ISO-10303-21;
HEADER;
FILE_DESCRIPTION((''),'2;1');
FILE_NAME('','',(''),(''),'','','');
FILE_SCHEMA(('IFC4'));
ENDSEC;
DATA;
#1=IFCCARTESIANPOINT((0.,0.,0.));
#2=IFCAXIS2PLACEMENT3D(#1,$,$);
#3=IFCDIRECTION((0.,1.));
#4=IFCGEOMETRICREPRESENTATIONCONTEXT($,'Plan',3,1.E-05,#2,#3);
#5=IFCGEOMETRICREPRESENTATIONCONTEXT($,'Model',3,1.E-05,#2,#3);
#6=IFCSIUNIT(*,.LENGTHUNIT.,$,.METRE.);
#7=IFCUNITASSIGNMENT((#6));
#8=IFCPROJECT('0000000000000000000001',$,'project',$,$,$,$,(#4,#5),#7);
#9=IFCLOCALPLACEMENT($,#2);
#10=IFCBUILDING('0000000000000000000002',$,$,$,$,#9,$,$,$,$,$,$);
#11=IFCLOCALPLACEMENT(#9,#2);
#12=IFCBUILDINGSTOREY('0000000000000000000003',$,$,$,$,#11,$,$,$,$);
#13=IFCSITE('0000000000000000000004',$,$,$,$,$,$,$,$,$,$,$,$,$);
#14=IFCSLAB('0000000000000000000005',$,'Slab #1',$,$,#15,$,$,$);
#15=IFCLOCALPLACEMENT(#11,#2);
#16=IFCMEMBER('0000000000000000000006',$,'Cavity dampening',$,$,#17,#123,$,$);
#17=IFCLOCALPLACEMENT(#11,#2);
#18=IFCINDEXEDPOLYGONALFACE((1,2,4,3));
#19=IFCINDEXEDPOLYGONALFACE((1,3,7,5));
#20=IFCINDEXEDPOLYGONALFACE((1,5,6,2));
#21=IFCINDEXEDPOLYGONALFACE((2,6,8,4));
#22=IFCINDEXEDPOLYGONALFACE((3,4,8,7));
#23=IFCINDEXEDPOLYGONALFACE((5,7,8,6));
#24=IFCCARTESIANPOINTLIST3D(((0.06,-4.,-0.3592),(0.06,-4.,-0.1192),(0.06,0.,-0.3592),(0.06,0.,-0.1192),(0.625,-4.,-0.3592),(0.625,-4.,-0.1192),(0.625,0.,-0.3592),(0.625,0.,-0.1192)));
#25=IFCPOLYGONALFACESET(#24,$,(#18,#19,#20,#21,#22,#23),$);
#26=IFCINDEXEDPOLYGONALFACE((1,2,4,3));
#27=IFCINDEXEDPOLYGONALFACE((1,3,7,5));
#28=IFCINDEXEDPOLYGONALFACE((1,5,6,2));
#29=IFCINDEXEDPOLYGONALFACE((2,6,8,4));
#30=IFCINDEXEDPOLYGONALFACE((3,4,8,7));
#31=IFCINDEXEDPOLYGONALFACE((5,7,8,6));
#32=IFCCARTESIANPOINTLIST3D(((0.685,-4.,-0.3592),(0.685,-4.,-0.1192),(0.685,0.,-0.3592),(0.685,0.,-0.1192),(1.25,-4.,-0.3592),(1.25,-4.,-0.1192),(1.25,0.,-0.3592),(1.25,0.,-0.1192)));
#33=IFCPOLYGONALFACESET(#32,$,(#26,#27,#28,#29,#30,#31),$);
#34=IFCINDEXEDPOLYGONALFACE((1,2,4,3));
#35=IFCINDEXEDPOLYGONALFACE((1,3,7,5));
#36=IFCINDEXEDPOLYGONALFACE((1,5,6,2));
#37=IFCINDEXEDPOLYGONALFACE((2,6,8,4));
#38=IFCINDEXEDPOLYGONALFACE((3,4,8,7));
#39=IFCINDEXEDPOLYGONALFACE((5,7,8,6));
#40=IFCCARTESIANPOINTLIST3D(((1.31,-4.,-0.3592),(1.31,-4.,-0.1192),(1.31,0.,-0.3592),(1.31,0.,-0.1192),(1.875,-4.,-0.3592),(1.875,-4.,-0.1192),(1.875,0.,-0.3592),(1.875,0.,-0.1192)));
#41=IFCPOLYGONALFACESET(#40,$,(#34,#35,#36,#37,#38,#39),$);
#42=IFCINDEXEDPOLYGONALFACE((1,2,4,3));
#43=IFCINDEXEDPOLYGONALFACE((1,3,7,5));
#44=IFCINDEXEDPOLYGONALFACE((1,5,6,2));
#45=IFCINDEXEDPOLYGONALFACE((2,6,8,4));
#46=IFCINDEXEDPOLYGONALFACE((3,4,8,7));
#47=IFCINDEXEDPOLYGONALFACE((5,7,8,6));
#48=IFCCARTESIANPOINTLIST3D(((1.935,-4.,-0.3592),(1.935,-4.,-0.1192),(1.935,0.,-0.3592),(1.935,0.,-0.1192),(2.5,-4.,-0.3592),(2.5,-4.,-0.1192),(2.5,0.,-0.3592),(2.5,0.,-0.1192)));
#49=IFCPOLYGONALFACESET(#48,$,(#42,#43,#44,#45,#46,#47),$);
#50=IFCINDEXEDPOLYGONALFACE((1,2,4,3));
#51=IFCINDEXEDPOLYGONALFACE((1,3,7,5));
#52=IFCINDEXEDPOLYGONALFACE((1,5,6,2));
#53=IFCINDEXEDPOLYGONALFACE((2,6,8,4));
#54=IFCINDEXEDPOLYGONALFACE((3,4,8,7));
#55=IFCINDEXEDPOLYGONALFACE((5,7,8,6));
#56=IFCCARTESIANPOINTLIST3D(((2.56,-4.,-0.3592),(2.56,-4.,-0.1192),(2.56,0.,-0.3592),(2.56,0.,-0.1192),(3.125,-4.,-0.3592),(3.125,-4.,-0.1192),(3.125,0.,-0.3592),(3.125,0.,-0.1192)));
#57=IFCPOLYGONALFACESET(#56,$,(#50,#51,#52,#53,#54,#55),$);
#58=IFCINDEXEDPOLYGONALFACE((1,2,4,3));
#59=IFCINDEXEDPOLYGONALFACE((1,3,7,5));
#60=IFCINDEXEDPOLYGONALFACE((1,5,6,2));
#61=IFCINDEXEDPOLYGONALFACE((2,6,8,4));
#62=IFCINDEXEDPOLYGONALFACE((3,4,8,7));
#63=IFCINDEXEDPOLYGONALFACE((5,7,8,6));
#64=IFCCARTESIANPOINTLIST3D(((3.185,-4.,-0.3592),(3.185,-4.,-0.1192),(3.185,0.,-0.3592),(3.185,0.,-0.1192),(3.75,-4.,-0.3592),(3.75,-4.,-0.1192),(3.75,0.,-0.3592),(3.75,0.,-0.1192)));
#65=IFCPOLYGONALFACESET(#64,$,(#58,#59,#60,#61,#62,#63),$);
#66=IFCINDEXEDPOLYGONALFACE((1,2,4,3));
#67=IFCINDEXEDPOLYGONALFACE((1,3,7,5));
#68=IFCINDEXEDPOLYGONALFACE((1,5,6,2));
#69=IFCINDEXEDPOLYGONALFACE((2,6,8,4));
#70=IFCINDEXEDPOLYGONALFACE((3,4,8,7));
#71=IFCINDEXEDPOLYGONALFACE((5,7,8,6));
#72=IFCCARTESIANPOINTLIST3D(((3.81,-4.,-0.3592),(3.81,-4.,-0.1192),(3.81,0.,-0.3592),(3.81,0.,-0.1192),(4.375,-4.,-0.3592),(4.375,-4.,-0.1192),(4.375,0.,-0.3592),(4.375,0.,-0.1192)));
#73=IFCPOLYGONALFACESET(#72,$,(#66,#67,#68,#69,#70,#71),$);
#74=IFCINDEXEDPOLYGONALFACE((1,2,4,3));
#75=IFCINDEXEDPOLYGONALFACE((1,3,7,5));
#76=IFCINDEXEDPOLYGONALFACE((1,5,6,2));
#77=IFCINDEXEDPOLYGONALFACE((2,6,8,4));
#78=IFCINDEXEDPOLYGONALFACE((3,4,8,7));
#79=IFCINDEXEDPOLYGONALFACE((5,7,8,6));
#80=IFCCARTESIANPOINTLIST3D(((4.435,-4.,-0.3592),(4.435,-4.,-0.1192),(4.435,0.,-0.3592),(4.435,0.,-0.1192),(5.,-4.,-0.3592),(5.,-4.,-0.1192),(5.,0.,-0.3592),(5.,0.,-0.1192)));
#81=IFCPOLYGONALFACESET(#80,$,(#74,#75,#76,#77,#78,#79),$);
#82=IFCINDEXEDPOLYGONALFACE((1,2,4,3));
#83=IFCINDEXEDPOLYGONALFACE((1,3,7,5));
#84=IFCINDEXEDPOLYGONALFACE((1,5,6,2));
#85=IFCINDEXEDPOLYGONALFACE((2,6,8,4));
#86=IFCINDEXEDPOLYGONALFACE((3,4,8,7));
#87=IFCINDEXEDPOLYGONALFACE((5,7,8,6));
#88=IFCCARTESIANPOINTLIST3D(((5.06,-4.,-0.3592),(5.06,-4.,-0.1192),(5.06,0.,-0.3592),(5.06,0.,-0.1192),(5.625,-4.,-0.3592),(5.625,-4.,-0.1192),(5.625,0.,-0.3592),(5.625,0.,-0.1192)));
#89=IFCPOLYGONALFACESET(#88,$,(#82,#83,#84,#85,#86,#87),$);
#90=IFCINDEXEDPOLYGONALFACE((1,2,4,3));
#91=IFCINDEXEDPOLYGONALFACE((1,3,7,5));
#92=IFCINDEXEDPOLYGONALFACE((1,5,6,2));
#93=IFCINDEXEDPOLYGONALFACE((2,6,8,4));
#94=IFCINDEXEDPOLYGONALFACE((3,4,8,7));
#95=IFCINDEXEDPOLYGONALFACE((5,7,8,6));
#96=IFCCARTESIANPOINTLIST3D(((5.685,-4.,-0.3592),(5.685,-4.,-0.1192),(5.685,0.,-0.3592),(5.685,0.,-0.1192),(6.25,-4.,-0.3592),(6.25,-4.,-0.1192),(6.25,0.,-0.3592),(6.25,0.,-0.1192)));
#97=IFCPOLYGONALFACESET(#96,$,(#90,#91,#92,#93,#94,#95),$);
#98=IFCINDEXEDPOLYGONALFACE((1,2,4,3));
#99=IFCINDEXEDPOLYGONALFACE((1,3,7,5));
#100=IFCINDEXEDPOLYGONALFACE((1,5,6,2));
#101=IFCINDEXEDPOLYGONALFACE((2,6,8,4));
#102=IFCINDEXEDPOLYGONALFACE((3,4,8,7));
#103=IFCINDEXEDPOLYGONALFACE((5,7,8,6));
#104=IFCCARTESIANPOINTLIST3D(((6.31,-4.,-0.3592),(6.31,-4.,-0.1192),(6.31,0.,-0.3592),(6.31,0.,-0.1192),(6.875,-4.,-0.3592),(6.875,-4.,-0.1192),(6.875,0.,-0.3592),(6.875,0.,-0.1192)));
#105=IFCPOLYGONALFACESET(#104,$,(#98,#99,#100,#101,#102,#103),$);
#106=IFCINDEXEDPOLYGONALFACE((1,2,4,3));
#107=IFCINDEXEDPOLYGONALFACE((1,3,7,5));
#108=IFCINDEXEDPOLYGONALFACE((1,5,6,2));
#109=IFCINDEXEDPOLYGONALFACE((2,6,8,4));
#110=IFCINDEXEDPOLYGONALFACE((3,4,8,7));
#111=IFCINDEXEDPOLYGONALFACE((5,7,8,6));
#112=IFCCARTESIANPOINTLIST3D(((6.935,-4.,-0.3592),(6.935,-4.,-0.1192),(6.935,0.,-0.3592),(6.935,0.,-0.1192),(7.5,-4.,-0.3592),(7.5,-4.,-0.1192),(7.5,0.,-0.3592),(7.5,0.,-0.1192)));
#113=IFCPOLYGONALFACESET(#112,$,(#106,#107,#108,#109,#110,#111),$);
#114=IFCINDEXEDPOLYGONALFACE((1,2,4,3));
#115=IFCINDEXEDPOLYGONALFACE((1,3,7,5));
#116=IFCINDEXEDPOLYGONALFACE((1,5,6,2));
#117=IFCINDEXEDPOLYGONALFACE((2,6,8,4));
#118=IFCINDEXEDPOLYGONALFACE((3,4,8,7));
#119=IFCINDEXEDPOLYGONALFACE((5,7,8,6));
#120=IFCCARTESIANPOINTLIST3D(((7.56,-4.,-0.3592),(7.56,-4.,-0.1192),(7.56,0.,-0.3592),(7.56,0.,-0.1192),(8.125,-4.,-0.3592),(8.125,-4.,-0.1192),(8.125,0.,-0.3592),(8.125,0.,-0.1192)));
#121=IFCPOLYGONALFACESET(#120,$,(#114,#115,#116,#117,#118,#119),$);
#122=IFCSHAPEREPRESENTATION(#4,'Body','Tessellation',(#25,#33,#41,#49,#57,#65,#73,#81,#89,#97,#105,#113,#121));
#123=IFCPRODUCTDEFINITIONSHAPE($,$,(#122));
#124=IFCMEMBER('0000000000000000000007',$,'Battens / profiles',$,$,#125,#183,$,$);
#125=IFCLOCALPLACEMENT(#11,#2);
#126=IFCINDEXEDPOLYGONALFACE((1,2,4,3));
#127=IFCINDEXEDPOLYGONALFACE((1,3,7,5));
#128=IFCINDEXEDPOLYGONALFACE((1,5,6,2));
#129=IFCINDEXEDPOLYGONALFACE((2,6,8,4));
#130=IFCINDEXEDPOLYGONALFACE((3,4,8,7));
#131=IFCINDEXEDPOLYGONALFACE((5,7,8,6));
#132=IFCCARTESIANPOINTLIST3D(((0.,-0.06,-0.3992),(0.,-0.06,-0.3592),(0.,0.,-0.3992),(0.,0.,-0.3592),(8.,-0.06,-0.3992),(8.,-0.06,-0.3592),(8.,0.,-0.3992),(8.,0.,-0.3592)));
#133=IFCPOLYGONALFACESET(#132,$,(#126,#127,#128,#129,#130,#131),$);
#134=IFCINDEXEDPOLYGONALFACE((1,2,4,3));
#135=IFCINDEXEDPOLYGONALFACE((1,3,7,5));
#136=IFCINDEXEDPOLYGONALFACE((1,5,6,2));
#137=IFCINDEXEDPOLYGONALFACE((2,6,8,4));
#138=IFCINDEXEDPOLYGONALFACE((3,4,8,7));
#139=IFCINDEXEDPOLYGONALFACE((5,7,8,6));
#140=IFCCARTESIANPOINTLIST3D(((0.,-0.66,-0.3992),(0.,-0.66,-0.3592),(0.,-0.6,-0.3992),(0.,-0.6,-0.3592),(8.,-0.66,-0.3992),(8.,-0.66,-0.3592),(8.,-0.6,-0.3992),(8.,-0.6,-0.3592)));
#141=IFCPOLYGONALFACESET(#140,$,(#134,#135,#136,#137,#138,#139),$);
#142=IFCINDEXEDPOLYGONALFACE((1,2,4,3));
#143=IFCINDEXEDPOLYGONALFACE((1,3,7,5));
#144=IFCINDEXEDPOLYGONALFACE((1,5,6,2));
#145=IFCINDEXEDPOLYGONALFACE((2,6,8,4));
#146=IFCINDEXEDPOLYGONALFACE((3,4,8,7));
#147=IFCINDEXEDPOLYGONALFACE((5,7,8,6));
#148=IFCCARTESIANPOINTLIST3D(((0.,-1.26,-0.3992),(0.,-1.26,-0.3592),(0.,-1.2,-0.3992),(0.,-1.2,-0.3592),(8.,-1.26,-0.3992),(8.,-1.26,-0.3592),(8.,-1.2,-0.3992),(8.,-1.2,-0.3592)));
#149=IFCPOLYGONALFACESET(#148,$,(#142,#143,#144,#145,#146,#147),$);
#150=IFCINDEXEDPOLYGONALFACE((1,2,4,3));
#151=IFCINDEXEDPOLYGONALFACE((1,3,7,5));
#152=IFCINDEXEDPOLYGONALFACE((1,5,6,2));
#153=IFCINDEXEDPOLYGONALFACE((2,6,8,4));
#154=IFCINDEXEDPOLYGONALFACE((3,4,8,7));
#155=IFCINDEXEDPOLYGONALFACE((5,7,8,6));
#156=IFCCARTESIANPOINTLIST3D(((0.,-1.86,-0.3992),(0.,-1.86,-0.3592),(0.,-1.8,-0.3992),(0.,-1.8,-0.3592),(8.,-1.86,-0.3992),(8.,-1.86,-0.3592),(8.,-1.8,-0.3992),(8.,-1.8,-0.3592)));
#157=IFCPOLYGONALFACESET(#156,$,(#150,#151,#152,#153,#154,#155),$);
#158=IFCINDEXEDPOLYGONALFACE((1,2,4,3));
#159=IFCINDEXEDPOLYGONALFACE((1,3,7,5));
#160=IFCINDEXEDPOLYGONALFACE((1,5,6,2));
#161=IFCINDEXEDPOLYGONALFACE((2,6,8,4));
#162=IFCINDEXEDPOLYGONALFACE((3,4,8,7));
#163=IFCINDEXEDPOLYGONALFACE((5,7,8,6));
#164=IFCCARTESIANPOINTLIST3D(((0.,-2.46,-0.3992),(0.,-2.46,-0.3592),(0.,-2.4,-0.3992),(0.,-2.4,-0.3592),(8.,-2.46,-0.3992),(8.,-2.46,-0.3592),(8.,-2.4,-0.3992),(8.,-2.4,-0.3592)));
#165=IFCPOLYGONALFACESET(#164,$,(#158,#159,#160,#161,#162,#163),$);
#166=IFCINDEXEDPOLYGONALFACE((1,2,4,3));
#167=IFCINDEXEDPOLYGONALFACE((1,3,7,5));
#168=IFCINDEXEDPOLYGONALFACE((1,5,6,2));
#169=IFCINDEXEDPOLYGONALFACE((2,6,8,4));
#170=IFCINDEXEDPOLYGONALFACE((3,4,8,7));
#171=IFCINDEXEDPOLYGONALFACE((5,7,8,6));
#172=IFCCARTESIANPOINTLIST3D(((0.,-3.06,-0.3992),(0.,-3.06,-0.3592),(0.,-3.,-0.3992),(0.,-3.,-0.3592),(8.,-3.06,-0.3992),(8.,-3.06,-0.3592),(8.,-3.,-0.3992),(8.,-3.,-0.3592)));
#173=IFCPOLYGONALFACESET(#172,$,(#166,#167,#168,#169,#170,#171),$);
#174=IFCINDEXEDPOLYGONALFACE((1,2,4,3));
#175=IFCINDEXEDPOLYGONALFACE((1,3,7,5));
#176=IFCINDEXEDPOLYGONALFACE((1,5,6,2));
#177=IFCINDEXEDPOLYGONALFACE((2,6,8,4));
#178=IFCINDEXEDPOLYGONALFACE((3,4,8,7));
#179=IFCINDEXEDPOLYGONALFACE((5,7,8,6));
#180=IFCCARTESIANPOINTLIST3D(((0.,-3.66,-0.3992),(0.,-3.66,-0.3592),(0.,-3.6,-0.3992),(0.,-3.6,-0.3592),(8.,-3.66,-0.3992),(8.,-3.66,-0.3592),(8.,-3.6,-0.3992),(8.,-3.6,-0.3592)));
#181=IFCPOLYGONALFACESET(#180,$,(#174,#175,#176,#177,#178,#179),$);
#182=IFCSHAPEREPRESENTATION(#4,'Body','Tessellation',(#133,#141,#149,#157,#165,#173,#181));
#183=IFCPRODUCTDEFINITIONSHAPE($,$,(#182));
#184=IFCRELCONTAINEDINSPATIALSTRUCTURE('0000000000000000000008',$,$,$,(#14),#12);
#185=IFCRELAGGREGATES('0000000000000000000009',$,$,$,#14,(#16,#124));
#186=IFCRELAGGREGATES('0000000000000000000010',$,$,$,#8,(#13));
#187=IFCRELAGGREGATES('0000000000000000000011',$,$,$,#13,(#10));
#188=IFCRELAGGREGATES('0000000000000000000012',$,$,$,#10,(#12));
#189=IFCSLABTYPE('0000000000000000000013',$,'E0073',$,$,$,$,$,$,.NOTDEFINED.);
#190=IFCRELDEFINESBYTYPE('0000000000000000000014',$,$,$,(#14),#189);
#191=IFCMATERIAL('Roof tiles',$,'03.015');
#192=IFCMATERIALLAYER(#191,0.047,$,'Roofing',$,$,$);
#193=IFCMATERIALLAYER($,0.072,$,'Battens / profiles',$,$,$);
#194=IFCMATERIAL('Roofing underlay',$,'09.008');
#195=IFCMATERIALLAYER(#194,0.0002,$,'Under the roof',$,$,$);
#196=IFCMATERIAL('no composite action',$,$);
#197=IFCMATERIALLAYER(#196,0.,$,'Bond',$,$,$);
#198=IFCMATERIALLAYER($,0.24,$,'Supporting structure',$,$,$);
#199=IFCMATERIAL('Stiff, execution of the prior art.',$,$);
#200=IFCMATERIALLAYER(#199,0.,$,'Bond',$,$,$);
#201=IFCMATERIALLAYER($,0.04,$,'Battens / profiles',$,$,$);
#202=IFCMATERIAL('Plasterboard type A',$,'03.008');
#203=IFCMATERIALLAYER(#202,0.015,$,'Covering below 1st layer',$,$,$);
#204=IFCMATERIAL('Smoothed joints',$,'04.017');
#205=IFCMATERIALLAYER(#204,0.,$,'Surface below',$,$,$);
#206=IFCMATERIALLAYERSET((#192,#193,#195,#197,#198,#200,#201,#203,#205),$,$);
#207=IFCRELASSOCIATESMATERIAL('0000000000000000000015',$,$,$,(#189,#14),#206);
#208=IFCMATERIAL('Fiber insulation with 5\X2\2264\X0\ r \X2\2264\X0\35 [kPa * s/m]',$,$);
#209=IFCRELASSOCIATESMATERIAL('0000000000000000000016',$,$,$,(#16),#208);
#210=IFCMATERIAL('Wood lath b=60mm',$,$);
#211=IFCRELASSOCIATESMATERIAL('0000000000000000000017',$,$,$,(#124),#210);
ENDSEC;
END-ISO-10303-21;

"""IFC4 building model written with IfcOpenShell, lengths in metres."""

from ifc_helpers import new_model, si_unit, direction, frame, frame_2d, origin, place, context, project, spatial, rectangle, extrude, material, layer, layer_set, type_object, element, aggregate, save


model = new_model("IFC4")

# Units and contexts
plan_context = context("Plan", 3, precision=1e-05, world=origin(), true_north=direction((0.0, 1.0)))
model_context = context("Model", 3, precision=1e-05, world=origin(), true_north=direction((0.0, 1.0)))
ifc_project = project(units=[si_unit("LENGTHUNIT", "METRE")], contexts=[plan_context, model_context])

# Site, building, storey
site = spatial("IfcSite", under=ifc_project)
building_placement = place(None, origin())
building = spatial("IfcBuilding", under=site, at=building_placement)
storey_placement = place(building_placement, origin())
storey = spatial("IfcBuildingStorey", under=building, at=storey_placement)

# Slab, members
ifc_material_1 = material(Name="Roof tiles", Category="03.015")
ifc_layer_1 = layer(ifc_material_1, 0.047, Name="Roofing")
ifc_layer_2 = layer(None, 0.072, Name="Battens / profiles")
ifc_material_2 = material(Name="Roofing underlay", Category="09.008")
ifc_layer_3 = layer(ifc_material_2, 0.0002, Name="Under the roof")
ifc_material_3 = material(Name="no composite action")
ifc_layer_4 = layer(ifc_material_3, 0.0, Name="Bond")
ifc_layer_5 = layer(None, 0.24, Name="Supporting structure")
ifc_material_4 = material(Name="Stiff, execution of the prior art.")
ifc_layer_6 = layer(ifc_material_4, 0.0, Name="Bond")
ifc_layer_7 = layer(None, 0.04, Name="Battens / profiles")
ifc_material_5 = material(Name="Plasterboard type A", Category="03.008")
ifc_layer_8 = layer(ifc_material_5, 0.015, Name="Covering below 1st layer")
ifc_material_6 = material(Name="Smoothed joints", Category="04.017")
ifc_layer_9 = layer(ifc_material_6, 0.0, Name="Surface below")
ifc_layer_set = layer_set([ifc_layer_1, ifc_layer_2, ifc_layer_3, ifc_layer_4, ifc_layer_5, ifc_layer_6, ifc_layer_7, ifc_layer_8, ifc_layer_9])
slab_type = type_object("IfcSlabType", Name="E0073", PredefinedType="NOTDEFINED", material=ifc_layer_set)
slab_placement = place(None, frame((0.0, 0.0, 0.0), z_axis=(0.0, 0.0, -1.0), x_axis=(1.0, 0.0, 0.0)))
slab = element("IfcSlab", 1, at=slab_placement, inside=storey, type_object=slab_type, material=ifc_layer_set, Name="Slab #1")
ifc_material_7 = material(Name="Fiber insulation with 5≤ r ≤35 [kPa * s/m]")
member_1_placement = place(slab_placement, origin())
member_1 = element("IfcMember", 2, at=member_1_placement, material=ifc_material_7, Name="Cavity dampening", context=plan_context, shape_type="SweptSolid", body=[
    extrude(rectangle(XDim=0.565, YDim=0.24, at=frame_2d((0.2825, 0.12), x_axis=(1.0, 0.0))), frame((0.06, 4.0, 0.1192), z_axis=(0.0, -1.0, 0.0), x_axis=(1.0, 0.0, 0.0)), (0.0, 0.0, 1.0), 4.0),
    extrude(rectangle(XDim=0.565, YDim=0.24, at=frame_2d((0.2825, 0.12), x_axis=(1.0, 0.0))), frame((0.685, 4.0, 0.1192), z_axis=(0.0, -1.0, 0.0), x_axis=(1.0, 0.0, 0.0)), (0.0, 0.0, 1.0), 4.0),
    extrude(rectangle(XDim=0.565, YDim=0.24, at=frame_2d((0.2825, 0.12), x_axis=(1.0, 0.0))), frame((1.31, 4.0, 0.1192), z_axis=(0.0, -1.0, 0.0), x_axis=(1.0, 0.0, 0.0)), (0.0, 0.0, 1.0), 4.0),
    extrude(rectangle(XDim=0.565, YDim=0.24, at=frame_2d((0.2825, 0.12), x_axis=(1.0, 0.0))), frame((1.935, 4.0, 0.1192), z_axis=(0.0, -1.0, 0.0), x_axis=(1.0, 0.0, 0.0)), (0.0, 0.0, 1.0), 4.0),
    extrude(rectangle(XDim=0.565, YDim=0.24, at=frame_2d((0.2825, 0.12), x_axis=(1.0, 0.0))), frame((2.56, 4.0, 0.1192), z_axis=(0.0, -1.0, 0.0), x_axis=(1.0, 0.0, 0.0)), (0.0, 0.0, 1.0), 4.0),
    extrude(rectangle(XDim=0.565, YDim=0.24, at=frame_2d((0.2825, 0.12), x_axis=(1.0, 0.0))), frame((3.185, 4.0, 0.1192), z_axis=(0.0, -1.0, 0.0), x_axis=(1.0, 0.0, 0.0)), (0.0, 0.0, 1.0), 4.0),
    extrude(rectangle(XDim=0.565, YDim=0.24, at=frame_2d((0.2825, 0.12), x_axis=(1.0, 0.0))), frame((3.81, 4.0, 0.1192), z_axis=(0.0, -1.0, 0.0), x_axis=(1.0, 0.0, 0.0)), (0.0, 0.0, 1.0), 4.0),
    extrude(rectangle(XDim=0.565, YDim=0.24, at=frame_2d((0.2825, 0.12), x_axis=(1.0, 0.0))), frame((4.435, 4.0, 0.1192), z_axis=(0.0, -1.0, 0.0), x_axis=(1.0, 0.0, 0.0)), (0.0, 0.0, 1.0), 4.0),
    extrude(rectangle(XDim=0.565, YDim=0.24, at=frame_2d((0.2825, 0.12), x_axis=(1.0, 0.0))), frame((5.06, 4.0, 0.1192), z_axis=(0.0, -1.0, 0.0), x_axis=(1.0, 0.0, 0.0)), (0.0, 0.0, 1.0), 4.0),
    extrude(rectangle(XDim=0.565, YDim=0.24, at=frame_2d((0.2825, 0.12), x_axis=(1.0, 0.0))), frame((5.685, 4.0, 0.1192), z_axis=(0.0, -1.0, 0.0), x_axis=(1.0, 0.0, 0.0)), (0.0, 0.0, 1.0), 4.0),
    extrude(rectangle(XDim=0.565, YDim=0.24, at=frame_2d((0.2825, 0.12), x_axis=(1.0, 0.0))), frame((6.31, 4.0, 0.1192), z_axis=(0.0, -1.0, 0.0), x_axis=(1.0, 0.0, 0.0)), (0.0, 0.0, 1.0), 4.0),
    extrude(rectangle(XDim=0.565, YDim=0.24, at=frame_2d((0.2825, 0.12), x_axis=(1.0, 0.0))), frame((6.935, 4.0, 0.1192), z_axis=(0.0, -1.0, 0.0), x_axis=(1.0, 0.0, 0.0)), (0.0, 0.0, 1.0), 4.0),
    extrude(rectangle(XDim=0.565, YDim=0.24, at=frame_2d((0.2825, 0.12), x_axis=(1.0, 0.0))), frame((7.56, 4.0, 0.1192), z_axis=(0.0, -1.0, 0.0), x_axis=(1.0, 0.0, 0.0)), (0.0, 0.0, 1.0), 4.0),
])
ifc_material_8 = material(Name="Wood lath b=60mm")
member_2_placement = place(slab_placement, origin())
member_2 = element("IfcMember", 3, at=member_2_placement, material=ifc_material_8, Name="Battens / profiles", context=plan_context, shape_type="SweptSolid", body=[
    extrude(rectangle(XDim=0.06, YDim=0.04, at=frame_2d((0.03, 0.02), x_axis=(1.0, 0.0))), frame((0.0, 0.0, 0.3592), z_axis=(1.0, 0.0, 0.0), x_axis=(0.0, 1.0, 0.0)), (0.0, 0.0, 1.0), 8.0),
    extrude(rectangle(XDim=0.06, YDim=0.04, at=frame_2d((0.03, 0.02), x_axis=(1.0, 0.0))), frame((0.0, 0.6, 0.3592), z_axis=(1.0, 0.0, 0.0), x_axis=(0.0, 1.0, 0.0)), (0.0, 0.0, 1.0), 8.0),
    extrude(rectangle(XDim=0.06, YDim=0.04, at=frame_2d((0.03, 0.02), x_axis=(1.0, 0.0))), frame((0.0, 1.2, 0.3592), z_axis=(1.0, 0.0, 0.0), x_axis=(0.0, 1.0, 0.0)), (0.0, 0.0, 1.0), 8.0),
    extrude(rectangle(XDim=0.06, YDim=0.04, at=frame_2d((0.03, 0.02), x_axis=(1.0, 0.0))), frame((0.0, 1.8, 0.3592), z_axis=(1.0, 0.0, 0.0), x_axis=(0.0, 1.0, 0.0)), (0.0, 0.0, 1.0), 8.0),
    extrude(rectangle(XDim=0.06, YDim=0.04, at=frame_2d((0.03, 0.02), x_axis=(1.0, 0.0))), frame((0.0, 2.4, 0.3592), z_axis=(1.0, 0.0, 0.0), x_axis=(0.0, 1.0, 0.0)), (0.0, 0.0, 1.0), 8.0),
    extrude(rectangle(XDim=0.06, YDim=0.04, at=frame_2d((0.03, 0.02), x_axis=(1.0, 0.0))), frame((0.0, 3.0, 0.3592), z_axis=(1.0, 0.0, 0.0), x_axis=(0.0, 1.0, 0.0)), (0.0, 0.0, 1.0), 8.0),
    extrude(rectangle(XDim=0.06, YDim=0.04, at=frame_2d((0.03, 0.02), x_axis=(1.0, 0.0))), frame((0.0, 3.6, 0.3592), z_axis=(1.0, 0.0, 0.0), x_axis=(0.0, 1.0, 0.0)), (0.0, 0.0, 1.0), 8.0),
])
aggregate(slab, [member_1, member_2])

save(model, "model.ifc")
